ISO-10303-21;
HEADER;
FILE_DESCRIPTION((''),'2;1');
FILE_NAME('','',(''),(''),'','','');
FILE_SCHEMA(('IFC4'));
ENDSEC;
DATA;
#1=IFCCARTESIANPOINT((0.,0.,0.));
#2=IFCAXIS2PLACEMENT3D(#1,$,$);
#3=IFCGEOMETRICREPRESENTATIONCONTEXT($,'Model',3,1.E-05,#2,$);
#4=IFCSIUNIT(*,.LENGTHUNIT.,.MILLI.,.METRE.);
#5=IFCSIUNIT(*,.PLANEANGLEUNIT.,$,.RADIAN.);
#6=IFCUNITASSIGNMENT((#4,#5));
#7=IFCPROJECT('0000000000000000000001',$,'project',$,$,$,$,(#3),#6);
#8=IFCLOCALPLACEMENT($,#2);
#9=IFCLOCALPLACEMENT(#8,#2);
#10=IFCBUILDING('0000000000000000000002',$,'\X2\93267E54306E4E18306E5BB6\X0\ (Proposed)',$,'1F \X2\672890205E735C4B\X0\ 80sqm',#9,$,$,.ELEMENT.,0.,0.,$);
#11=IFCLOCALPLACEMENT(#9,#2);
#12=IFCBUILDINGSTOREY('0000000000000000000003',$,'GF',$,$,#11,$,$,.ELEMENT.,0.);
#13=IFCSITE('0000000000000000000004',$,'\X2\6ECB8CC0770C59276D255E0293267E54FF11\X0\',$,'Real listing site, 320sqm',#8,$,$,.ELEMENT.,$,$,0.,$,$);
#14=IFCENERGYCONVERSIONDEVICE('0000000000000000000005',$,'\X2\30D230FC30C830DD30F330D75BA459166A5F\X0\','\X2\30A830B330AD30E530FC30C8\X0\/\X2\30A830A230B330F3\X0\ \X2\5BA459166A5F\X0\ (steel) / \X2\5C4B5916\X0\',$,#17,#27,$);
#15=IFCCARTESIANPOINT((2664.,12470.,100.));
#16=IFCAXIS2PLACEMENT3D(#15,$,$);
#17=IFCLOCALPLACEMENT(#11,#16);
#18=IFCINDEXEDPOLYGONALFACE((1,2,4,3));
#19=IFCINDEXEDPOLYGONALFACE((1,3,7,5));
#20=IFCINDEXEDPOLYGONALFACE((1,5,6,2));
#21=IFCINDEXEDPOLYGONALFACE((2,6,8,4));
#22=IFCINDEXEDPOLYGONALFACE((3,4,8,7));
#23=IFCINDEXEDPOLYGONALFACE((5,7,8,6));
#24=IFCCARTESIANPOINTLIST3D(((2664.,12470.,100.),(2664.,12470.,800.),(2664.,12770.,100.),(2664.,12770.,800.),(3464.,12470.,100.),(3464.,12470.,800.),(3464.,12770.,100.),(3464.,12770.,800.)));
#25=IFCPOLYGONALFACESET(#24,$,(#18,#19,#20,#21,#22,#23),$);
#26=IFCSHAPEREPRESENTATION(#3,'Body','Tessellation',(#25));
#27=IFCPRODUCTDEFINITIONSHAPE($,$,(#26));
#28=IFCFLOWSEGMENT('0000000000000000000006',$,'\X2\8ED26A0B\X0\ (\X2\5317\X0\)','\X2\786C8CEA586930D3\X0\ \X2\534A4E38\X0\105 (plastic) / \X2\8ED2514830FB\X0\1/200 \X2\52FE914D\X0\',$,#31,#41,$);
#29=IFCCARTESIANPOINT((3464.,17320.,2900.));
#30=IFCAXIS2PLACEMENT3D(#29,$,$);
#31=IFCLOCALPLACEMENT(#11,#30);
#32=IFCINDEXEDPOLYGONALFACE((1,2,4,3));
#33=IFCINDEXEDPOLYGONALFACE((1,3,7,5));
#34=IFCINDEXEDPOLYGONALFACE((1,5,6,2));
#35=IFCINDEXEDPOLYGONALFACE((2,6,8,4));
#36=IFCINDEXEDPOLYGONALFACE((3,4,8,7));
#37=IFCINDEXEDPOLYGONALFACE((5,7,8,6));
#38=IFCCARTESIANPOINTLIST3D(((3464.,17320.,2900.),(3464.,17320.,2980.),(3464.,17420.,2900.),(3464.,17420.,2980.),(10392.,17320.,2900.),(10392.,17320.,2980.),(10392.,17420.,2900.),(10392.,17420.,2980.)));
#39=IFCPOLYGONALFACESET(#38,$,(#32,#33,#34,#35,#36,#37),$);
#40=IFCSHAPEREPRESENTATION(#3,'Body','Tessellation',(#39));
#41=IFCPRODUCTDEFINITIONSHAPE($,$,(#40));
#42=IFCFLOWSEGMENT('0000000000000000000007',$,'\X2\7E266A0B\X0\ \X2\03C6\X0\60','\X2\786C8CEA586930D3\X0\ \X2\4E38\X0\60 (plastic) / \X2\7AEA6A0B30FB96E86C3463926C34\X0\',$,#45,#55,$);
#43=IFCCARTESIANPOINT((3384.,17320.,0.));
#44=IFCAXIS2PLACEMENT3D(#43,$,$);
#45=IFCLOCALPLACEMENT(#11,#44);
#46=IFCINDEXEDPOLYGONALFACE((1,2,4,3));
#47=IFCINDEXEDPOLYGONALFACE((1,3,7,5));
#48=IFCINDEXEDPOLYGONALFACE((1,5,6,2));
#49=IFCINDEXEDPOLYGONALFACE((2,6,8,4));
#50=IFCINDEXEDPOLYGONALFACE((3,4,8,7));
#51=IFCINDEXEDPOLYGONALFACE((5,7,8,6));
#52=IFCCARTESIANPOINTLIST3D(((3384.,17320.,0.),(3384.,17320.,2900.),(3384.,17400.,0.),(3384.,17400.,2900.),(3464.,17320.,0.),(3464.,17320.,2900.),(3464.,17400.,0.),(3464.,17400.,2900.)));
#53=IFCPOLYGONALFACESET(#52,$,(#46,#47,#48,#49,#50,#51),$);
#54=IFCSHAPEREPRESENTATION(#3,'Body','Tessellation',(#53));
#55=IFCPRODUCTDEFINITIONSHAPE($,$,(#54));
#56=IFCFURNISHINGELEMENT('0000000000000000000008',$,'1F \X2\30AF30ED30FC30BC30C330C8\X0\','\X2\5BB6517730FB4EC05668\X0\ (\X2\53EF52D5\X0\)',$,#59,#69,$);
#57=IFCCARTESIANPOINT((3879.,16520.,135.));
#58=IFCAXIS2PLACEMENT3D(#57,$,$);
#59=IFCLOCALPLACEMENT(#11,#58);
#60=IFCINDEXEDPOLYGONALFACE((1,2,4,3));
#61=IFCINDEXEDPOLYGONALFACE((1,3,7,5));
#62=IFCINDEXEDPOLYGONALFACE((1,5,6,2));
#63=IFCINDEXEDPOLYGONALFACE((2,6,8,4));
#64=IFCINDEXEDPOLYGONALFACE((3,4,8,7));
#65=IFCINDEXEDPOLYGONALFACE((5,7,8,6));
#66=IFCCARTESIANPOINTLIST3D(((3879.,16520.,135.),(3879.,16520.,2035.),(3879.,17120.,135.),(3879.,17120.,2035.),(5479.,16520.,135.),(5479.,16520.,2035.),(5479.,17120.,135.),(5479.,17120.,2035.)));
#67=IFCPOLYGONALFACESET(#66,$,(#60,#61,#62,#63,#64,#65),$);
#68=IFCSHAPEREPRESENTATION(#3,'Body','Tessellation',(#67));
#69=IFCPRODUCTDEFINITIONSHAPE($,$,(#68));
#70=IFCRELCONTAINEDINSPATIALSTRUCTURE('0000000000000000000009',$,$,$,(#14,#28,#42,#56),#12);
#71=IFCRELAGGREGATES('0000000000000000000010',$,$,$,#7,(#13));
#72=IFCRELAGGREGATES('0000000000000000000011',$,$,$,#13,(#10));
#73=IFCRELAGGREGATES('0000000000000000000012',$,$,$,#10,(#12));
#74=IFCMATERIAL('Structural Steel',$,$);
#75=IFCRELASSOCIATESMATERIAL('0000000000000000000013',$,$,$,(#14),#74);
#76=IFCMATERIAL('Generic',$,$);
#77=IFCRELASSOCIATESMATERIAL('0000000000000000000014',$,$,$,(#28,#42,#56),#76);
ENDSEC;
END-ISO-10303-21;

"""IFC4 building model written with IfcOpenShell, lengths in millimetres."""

from ifc_helpers import new_model, si_unit, frame, frame_2d, origin, place, context, project, spatial, rectangle, extrude, material, element, save


model = new_model("IFC4")

# Units and contexts
model_context = context("Model", 3, precision=1e-05, world=origin())
ifc_project = project(units=[si_unit("LENGTHUNIT", "METRE", prefix="MILLI"), si_unit("PLANEANGLEUNIT", "RADIAN")], contexts=[model_context])

# Site, building, storey
site_placement = place(None, origin())
site = spatial("IfcSite", under=ifc_project, at=site_placement, Name="滋賀県大津市錦織１", ObjectType="Real listing site, 320sqm", CompositionType="ELEMENT", RefElevation=0.0)
building_placement = place(site_placement, origin())
building = spatial("IfcBuilding", under=site, at=building_placement, Name="錦織の丘の家 (Proposed)", ObjectType="1F 木造平屋 80sqm", CompositionType="ELEMENT", ElevationOfRefHeight=0.0, ElevationOfTerrain=0.0)
storey_placement = place(building_placement, origin())
storey = spatial("IfcBuildingStorey", under=building, at=storey_placement, Name="GF", CompositionType="ELEMENT", Elevation=0.0)

# Shared definitions
ifc_material_1 = material(Name="Structural Steel")

# Shared definitions
ifc_material_2 = material(Name="Generic")

# Energy conversion device
energy_conversion_device_placement = place(storey_placement, frame((2664.0, 12470.0, 100.0)))
element("IfcEnergyConversionDevice", 1, at=energy_conversion_device_placement, inside=storey, material=ifc_material_1, Name="ヒートポンプ室外機", Description="エコキュート/エアコン 室外機 (steel) / 屋外", context=model_context, shape_type="SweptSolid", body=[
    extrude(rectangle(XDim=800.0, YDim=300.0, at=frame_2d((400.0, 150.0))), frame((2664.0, 12470.0, 100.0)), (0.0, 0.0, 1.0), 700.0),
])

# Flow segments
flow_segment_1_placement = place(storey_placement, frame((3464.0, 17320.0, 2900.0)))
element("IfcFlowSegment", 2, at=flow_segment_1_placement, inside=storey, material=ifc_material_2, Name="軒樋 (北)", Description="硬質塩ビ 半丸105 (plastic) / 軒先・1/200 勾配", context=model_context, shape_type="SweptSolid", body=[
    extrude(rectangle(XDim=6928.0, YDim=100.0, at=frame_2d((3464.0, 50.0))), frame((3464.0, 17320.0, 2900.0)), (0.0, 0.0, 1.0), 80.0),
])
flow_segment_2_placement = place(storey_placement, frame((3384.0, 17320.0, 0.0)))
element("IfcFlowSegment", 3, at=flow_segment_2_placement, inside=storey, material=ifc_material_2, Name="縦樋 φ60", Description="硬質塩ビ 丸60 (plastic) / 竪樋・雨水排水", context=model_context, shape_type="SweptSolid", body=[
    extrude(rectangle(XDim=80.0, YDim=80.0, at=frame_2d((40.0, 40.0))), frame((3384.0, 17320.0, 0.0)), (0.0, 0.0, 1.0), 2900.0),
])

# Furnishing element
furnishing_placement = place(storey_placement, frame((3879.0, 16520.0, 135.0)))
element("IfcFurnishingElement", 4, at=furnishing_placement, inside=storey, material=ifc_material_2, Name="1F クローゼット", Description="家具・什器 (可動)", context=model_context, shape_type="SweptSolid", body=[
    extrude(rectangle(XDim=1600.0, YDim=600.0, at=frame_2d((800.0, 300.0))), frame((3879.0, 16520.0, 135.0)), (0.0, 0.0, 1.0), 1900.0),
])

save(model, "model.ifc")
